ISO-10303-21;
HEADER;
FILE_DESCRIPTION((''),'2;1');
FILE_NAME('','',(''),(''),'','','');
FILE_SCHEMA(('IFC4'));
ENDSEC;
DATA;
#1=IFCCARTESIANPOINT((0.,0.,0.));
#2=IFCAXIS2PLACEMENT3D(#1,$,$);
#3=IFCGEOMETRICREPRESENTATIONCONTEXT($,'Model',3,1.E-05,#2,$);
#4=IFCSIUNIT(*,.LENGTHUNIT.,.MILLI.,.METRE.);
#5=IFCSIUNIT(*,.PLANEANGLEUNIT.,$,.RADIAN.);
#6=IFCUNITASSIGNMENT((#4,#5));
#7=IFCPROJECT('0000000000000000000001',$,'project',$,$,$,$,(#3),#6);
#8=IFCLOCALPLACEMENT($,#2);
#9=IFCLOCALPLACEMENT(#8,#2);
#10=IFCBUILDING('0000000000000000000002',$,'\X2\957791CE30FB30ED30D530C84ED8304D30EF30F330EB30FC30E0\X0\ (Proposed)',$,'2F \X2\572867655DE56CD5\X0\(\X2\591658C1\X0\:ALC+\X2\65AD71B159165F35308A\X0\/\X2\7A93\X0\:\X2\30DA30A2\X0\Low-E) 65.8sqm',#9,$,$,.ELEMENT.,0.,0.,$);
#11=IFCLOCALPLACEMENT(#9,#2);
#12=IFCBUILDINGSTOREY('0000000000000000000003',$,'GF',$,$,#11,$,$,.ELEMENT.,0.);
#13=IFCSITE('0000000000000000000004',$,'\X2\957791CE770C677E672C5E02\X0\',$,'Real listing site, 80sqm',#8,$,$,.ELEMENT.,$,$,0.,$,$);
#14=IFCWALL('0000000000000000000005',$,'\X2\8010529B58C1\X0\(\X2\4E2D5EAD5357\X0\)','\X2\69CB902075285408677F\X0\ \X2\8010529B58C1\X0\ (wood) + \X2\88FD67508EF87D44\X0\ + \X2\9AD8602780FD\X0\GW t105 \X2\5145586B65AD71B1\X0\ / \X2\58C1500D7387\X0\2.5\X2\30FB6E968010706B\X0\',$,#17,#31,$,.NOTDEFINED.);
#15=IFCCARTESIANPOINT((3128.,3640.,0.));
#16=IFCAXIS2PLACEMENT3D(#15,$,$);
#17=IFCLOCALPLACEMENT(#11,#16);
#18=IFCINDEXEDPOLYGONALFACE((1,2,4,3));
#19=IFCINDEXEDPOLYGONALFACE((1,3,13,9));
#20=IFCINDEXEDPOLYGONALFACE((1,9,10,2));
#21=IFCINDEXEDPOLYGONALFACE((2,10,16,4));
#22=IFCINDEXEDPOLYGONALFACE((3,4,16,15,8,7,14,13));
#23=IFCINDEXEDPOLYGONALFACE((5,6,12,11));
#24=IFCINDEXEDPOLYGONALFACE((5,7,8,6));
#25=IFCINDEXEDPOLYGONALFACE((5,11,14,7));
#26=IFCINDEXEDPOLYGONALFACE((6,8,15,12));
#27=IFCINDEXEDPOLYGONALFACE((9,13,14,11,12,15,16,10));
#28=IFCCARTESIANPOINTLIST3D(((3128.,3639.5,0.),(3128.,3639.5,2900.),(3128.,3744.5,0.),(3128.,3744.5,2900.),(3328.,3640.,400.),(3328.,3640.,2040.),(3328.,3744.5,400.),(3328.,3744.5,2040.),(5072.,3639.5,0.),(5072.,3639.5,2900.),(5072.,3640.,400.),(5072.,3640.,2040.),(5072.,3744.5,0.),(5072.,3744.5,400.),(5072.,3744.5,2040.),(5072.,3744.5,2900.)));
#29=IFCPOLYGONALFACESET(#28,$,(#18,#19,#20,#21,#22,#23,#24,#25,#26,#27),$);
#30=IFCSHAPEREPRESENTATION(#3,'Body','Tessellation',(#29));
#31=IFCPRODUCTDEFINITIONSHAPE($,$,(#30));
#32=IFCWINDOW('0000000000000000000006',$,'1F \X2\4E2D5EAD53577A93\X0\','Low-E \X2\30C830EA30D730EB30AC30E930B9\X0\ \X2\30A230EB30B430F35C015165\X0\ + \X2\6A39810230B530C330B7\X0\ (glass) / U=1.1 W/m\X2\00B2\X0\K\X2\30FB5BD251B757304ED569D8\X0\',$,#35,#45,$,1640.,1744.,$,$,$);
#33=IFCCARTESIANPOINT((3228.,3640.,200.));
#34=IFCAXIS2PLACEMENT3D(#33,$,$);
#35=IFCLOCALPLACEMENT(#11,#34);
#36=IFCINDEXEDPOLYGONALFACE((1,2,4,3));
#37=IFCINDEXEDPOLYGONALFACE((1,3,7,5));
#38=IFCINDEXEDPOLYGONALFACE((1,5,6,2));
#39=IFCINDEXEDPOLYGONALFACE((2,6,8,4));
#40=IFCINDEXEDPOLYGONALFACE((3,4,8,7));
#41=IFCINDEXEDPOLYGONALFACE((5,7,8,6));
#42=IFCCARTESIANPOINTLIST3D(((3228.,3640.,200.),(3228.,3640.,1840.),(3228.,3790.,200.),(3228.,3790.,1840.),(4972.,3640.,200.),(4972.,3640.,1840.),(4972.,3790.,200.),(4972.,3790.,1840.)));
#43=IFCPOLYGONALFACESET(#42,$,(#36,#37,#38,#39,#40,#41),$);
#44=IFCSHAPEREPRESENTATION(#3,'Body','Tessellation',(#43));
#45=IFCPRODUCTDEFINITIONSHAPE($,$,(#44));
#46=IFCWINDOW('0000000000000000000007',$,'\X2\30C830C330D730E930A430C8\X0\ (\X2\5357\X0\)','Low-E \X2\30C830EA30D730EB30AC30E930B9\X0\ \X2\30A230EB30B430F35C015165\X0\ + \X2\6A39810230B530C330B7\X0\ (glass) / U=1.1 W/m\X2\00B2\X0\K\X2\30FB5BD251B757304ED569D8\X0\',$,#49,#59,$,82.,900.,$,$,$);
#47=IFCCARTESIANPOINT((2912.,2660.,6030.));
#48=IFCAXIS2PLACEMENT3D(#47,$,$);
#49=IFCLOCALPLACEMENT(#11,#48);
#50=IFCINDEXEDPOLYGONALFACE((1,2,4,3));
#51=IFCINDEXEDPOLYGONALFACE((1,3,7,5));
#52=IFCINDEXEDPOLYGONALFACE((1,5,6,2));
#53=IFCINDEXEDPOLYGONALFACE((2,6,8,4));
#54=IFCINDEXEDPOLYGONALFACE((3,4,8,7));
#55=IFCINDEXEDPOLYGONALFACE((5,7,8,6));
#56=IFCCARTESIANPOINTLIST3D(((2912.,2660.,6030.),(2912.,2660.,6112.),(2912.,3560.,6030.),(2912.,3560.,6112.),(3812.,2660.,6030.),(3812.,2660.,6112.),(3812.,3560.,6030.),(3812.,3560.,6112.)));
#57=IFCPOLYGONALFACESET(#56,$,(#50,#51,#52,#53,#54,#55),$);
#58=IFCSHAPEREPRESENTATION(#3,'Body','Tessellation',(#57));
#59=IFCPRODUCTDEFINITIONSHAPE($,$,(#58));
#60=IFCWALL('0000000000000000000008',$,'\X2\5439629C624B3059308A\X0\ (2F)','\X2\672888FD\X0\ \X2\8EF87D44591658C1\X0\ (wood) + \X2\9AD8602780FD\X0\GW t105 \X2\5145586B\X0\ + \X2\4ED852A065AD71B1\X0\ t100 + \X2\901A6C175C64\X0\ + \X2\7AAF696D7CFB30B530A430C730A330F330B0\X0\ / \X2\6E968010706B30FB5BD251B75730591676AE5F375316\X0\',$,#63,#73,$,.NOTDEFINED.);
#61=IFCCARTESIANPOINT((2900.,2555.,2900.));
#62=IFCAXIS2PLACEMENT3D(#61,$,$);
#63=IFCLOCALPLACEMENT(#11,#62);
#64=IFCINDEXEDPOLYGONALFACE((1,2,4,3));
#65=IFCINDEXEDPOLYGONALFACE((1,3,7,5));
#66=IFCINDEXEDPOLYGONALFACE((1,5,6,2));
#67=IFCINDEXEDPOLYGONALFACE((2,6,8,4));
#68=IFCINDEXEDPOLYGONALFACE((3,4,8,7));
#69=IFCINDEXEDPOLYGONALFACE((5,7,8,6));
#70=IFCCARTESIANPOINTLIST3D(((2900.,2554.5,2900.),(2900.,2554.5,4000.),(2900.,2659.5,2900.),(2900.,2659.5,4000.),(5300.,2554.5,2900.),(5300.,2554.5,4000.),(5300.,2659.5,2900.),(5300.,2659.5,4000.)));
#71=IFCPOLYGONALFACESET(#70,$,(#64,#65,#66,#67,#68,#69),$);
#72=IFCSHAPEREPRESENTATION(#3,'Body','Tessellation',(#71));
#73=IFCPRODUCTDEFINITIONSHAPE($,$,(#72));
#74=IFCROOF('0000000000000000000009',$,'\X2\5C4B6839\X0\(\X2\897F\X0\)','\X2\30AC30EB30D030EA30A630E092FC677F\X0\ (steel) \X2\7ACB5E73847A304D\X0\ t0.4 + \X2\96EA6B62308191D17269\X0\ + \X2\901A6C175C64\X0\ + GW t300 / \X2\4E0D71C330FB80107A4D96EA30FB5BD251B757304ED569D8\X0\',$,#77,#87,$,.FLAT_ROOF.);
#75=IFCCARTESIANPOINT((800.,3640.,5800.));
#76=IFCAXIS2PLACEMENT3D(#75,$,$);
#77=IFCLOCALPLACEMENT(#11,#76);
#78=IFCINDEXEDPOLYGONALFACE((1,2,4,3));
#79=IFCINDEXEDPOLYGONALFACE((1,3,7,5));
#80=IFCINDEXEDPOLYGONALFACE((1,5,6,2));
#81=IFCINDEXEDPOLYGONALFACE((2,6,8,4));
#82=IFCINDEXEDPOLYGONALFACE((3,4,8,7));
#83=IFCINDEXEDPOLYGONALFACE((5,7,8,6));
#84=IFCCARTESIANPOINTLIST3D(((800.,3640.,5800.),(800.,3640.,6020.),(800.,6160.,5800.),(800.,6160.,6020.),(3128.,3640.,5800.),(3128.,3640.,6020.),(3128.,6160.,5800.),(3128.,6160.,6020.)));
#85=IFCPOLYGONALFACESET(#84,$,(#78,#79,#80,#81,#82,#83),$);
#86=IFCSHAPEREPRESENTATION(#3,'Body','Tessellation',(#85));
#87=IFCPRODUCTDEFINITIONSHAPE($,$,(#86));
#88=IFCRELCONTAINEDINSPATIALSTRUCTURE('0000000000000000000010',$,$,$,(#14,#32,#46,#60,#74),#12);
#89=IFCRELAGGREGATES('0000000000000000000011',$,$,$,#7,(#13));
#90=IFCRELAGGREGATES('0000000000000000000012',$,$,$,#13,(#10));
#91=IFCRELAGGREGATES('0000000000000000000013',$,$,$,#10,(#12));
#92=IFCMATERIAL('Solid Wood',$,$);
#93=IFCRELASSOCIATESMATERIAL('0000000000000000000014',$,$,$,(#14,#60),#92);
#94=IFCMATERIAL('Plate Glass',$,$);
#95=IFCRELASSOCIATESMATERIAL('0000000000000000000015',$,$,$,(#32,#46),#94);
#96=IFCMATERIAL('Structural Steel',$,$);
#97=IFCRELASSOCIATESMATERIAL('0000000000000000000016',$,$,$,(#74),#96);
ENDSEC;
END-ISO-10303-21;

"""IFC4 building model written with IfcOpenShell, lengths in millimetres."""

from ifc_helpers import new_model, si_unit, frame, frame_2d, origin, place, context, project, spatial, rectangle, extrude, material, element, fill, save


model = new_model("IFC4")

# Units and contexts
model_context = context("Model", 3, precision=1e-05, world=origin())
ifc_project = project(units=[si_unit("LENGTHUNIT", "METRE", prefix="MILLI"), si_unit("PLANEANGLEUNIT", "RADIAN")], contexts=[model_context])

# Site, building, storey
site_placement = place(None, origin())
site = spatial("IfcSite", under=ifc_project, at=site_placement, Name="長野県松本市", ObjectType="Real listing site, 80sqm", CompositionType="ELEMENT", RefElevation=0.0)
building_placement = place(site_placement, origin())
building = spatial("IfcBuilding", under=site, at=building_placement, Name="長野・ロフト付きワンルーム (Proposed)", ObjectType="2F 在来工法(外壁:ALC+断熱外張り/窓:ペアLow-E) 65.8sqm", CompositionType="ELEMENT", ElevationOfRefHeight=0.0, ElevationOfTerrain=0.0)
storey_placement = place(building_placement, origin())
storey = spatial("IfcBuildingStorey", under=building, at=storey_placement, Name="GF", CompositionType="ELEMENT", Elevation=0.0)

# Shared definitions
ifc_material_1 = material(Name="Solid Wood")

# Wall, opening, window
wall_1_placement = place(storey_placement, frame((3128.0, 3640.0, 0.0)))
wall_1 = element("IfcWall", 1, at=wall_1_placement, inside=storey, material=ifc_material_1, Name="耐力壁(中庭南)", Description="構造用合板 耐力壁 (wood) + 製材軸組 + 高性能GW t105 充填断熱 / 壁倍率2.5・準耐火", PredefinedType="NOTDEFINED", context=model_context, shape_type="SweptSolid", body=[
    extrude(rectangle(XDim=1944.0, YDim=105.0, at=frame_2d((972.0, 52.0))), frame((3128.0, 3640.0, 0.0)), (0.0, 0.0, 1.0), 2900.0),
])
opening_placement = place(storey_placement, frame((3228.0, 3640.0, 200.0)))
opening = element("IfcOpeningElement", 2, at=opening_placement, cuts=wall_1, PredefinedType="NOTDEFINED", context=model_context, shape_type="SweptSolid", body=[
    extrude(rectangle(XDim=1744.0, YDim=150.0, at=frame_2d((872.0, 75.0))), frame((3228.0, 3640.0, 200.0)), (0.0, 0.0, 1.0), 1640.0),
])
ifc_material_2 = material(Name="Plate Glass")
window_1_placement = place(storey_placement, frame((3228.0, 3640.0, 200.0)))
window_1 = element("IfcWindow", 3, at=window_1_placement, inside=storey, material=ifc_material_2, Name="1F 中庭南窓", Description="Low-E トリプルガラス アルゴン封入 + 樹脂サッシ (glass) / U=1.1 W/m²K・寒冷地仕様", OverallHeight=1640.0, OverallWidth=1744.0, context=model_context, shape_type="SweptSolid", body=[
    extrude(rectangle(XDim=1744.0, YDim=150.0, at=frame_2d((872.0, 75.0))), frame((3228.0, 3640.0, 200.0)), (0.0, 0.0, 1.0), 1640.0),
])
fill(opening, window_1)

# Window
window_2_placement = place(storey_placement, frame((2912.0, 2660.0, 6030.0)))
element("IfcWindow", 4, at=window_2_placement, inside=storey, material=ifc_material_2, Name="トップライト (南)", Description="Low-E トリプルガラス アルゴン封入 + 樹脂サッシ (glass) / U=1.1 W/m²K・寒冷地仕様", OverallHeight=82.0, OverallWidth=900.0, context=model_context, shape_type="SweptSolid", body=[
    extrude(rectangle(XDim=900.0, YDim=900.0, at=frame_2d((450.0, 450.0))), frame((2912.0, 2660.0, 6030.0)), (0.0, 0.0, 1.0), 82.0),
])

# Wall
wall_2_placement = place(storey_placement, frame((2900.0, 2555.0, 2900.0)))
element("IfcWall", 5, at=wall_2_placement, inside=storey, material=ifc_material_1, Name="吹抜手すり (2F)", Description="木製 軸組外壁 (wood) + 高性能GW t105 充填 + 付加断熱 t100 + 通気層 + 窯業系サイディング / 準耐火・寒冷地外皮強化", PredefinedType="NOTDEFINED", context=model_context, shape_type="SweptSolid", body=[
    extrude(rectangle(XDim=2400.0, YDim=105.0, at=frame_2d((1200.0, 52.0))), frame((2900.0, 2555.0, 2900.0)), (0.0, 0.0, 1.0), 1100.0),
])

# Roof
ifc_material_3 = material(Name="Structural Steel")
for number, where, name in (
    (6, (800.0, 3640.0, 5800.0), "屋根(西)"),
):
    element("IfcRoof", number, at=place(storey_placement, frame(where)), inside=storey, material=ifc_material_3, Name=name, Description="ガルバリウム鋼板 (steel) 立平葺き t0.4 + 雪止め金物 + 通気層 + GW t300 / 不燃・耐積雪・寒冷地仕様", PredefinedType="FLAT_ROOF", context=model_context, shape_type="SweptSolid", body=[
        extrude(rectangle(XDim=2328.0, YDim=2520.0, at=frame_2d((1164.0, 1260.0))), frame((800.0, 3640.0, 5800.0)), (0.0, 0.0, 1.0), 220.0),
    ])

save(model, "model.ifc")
